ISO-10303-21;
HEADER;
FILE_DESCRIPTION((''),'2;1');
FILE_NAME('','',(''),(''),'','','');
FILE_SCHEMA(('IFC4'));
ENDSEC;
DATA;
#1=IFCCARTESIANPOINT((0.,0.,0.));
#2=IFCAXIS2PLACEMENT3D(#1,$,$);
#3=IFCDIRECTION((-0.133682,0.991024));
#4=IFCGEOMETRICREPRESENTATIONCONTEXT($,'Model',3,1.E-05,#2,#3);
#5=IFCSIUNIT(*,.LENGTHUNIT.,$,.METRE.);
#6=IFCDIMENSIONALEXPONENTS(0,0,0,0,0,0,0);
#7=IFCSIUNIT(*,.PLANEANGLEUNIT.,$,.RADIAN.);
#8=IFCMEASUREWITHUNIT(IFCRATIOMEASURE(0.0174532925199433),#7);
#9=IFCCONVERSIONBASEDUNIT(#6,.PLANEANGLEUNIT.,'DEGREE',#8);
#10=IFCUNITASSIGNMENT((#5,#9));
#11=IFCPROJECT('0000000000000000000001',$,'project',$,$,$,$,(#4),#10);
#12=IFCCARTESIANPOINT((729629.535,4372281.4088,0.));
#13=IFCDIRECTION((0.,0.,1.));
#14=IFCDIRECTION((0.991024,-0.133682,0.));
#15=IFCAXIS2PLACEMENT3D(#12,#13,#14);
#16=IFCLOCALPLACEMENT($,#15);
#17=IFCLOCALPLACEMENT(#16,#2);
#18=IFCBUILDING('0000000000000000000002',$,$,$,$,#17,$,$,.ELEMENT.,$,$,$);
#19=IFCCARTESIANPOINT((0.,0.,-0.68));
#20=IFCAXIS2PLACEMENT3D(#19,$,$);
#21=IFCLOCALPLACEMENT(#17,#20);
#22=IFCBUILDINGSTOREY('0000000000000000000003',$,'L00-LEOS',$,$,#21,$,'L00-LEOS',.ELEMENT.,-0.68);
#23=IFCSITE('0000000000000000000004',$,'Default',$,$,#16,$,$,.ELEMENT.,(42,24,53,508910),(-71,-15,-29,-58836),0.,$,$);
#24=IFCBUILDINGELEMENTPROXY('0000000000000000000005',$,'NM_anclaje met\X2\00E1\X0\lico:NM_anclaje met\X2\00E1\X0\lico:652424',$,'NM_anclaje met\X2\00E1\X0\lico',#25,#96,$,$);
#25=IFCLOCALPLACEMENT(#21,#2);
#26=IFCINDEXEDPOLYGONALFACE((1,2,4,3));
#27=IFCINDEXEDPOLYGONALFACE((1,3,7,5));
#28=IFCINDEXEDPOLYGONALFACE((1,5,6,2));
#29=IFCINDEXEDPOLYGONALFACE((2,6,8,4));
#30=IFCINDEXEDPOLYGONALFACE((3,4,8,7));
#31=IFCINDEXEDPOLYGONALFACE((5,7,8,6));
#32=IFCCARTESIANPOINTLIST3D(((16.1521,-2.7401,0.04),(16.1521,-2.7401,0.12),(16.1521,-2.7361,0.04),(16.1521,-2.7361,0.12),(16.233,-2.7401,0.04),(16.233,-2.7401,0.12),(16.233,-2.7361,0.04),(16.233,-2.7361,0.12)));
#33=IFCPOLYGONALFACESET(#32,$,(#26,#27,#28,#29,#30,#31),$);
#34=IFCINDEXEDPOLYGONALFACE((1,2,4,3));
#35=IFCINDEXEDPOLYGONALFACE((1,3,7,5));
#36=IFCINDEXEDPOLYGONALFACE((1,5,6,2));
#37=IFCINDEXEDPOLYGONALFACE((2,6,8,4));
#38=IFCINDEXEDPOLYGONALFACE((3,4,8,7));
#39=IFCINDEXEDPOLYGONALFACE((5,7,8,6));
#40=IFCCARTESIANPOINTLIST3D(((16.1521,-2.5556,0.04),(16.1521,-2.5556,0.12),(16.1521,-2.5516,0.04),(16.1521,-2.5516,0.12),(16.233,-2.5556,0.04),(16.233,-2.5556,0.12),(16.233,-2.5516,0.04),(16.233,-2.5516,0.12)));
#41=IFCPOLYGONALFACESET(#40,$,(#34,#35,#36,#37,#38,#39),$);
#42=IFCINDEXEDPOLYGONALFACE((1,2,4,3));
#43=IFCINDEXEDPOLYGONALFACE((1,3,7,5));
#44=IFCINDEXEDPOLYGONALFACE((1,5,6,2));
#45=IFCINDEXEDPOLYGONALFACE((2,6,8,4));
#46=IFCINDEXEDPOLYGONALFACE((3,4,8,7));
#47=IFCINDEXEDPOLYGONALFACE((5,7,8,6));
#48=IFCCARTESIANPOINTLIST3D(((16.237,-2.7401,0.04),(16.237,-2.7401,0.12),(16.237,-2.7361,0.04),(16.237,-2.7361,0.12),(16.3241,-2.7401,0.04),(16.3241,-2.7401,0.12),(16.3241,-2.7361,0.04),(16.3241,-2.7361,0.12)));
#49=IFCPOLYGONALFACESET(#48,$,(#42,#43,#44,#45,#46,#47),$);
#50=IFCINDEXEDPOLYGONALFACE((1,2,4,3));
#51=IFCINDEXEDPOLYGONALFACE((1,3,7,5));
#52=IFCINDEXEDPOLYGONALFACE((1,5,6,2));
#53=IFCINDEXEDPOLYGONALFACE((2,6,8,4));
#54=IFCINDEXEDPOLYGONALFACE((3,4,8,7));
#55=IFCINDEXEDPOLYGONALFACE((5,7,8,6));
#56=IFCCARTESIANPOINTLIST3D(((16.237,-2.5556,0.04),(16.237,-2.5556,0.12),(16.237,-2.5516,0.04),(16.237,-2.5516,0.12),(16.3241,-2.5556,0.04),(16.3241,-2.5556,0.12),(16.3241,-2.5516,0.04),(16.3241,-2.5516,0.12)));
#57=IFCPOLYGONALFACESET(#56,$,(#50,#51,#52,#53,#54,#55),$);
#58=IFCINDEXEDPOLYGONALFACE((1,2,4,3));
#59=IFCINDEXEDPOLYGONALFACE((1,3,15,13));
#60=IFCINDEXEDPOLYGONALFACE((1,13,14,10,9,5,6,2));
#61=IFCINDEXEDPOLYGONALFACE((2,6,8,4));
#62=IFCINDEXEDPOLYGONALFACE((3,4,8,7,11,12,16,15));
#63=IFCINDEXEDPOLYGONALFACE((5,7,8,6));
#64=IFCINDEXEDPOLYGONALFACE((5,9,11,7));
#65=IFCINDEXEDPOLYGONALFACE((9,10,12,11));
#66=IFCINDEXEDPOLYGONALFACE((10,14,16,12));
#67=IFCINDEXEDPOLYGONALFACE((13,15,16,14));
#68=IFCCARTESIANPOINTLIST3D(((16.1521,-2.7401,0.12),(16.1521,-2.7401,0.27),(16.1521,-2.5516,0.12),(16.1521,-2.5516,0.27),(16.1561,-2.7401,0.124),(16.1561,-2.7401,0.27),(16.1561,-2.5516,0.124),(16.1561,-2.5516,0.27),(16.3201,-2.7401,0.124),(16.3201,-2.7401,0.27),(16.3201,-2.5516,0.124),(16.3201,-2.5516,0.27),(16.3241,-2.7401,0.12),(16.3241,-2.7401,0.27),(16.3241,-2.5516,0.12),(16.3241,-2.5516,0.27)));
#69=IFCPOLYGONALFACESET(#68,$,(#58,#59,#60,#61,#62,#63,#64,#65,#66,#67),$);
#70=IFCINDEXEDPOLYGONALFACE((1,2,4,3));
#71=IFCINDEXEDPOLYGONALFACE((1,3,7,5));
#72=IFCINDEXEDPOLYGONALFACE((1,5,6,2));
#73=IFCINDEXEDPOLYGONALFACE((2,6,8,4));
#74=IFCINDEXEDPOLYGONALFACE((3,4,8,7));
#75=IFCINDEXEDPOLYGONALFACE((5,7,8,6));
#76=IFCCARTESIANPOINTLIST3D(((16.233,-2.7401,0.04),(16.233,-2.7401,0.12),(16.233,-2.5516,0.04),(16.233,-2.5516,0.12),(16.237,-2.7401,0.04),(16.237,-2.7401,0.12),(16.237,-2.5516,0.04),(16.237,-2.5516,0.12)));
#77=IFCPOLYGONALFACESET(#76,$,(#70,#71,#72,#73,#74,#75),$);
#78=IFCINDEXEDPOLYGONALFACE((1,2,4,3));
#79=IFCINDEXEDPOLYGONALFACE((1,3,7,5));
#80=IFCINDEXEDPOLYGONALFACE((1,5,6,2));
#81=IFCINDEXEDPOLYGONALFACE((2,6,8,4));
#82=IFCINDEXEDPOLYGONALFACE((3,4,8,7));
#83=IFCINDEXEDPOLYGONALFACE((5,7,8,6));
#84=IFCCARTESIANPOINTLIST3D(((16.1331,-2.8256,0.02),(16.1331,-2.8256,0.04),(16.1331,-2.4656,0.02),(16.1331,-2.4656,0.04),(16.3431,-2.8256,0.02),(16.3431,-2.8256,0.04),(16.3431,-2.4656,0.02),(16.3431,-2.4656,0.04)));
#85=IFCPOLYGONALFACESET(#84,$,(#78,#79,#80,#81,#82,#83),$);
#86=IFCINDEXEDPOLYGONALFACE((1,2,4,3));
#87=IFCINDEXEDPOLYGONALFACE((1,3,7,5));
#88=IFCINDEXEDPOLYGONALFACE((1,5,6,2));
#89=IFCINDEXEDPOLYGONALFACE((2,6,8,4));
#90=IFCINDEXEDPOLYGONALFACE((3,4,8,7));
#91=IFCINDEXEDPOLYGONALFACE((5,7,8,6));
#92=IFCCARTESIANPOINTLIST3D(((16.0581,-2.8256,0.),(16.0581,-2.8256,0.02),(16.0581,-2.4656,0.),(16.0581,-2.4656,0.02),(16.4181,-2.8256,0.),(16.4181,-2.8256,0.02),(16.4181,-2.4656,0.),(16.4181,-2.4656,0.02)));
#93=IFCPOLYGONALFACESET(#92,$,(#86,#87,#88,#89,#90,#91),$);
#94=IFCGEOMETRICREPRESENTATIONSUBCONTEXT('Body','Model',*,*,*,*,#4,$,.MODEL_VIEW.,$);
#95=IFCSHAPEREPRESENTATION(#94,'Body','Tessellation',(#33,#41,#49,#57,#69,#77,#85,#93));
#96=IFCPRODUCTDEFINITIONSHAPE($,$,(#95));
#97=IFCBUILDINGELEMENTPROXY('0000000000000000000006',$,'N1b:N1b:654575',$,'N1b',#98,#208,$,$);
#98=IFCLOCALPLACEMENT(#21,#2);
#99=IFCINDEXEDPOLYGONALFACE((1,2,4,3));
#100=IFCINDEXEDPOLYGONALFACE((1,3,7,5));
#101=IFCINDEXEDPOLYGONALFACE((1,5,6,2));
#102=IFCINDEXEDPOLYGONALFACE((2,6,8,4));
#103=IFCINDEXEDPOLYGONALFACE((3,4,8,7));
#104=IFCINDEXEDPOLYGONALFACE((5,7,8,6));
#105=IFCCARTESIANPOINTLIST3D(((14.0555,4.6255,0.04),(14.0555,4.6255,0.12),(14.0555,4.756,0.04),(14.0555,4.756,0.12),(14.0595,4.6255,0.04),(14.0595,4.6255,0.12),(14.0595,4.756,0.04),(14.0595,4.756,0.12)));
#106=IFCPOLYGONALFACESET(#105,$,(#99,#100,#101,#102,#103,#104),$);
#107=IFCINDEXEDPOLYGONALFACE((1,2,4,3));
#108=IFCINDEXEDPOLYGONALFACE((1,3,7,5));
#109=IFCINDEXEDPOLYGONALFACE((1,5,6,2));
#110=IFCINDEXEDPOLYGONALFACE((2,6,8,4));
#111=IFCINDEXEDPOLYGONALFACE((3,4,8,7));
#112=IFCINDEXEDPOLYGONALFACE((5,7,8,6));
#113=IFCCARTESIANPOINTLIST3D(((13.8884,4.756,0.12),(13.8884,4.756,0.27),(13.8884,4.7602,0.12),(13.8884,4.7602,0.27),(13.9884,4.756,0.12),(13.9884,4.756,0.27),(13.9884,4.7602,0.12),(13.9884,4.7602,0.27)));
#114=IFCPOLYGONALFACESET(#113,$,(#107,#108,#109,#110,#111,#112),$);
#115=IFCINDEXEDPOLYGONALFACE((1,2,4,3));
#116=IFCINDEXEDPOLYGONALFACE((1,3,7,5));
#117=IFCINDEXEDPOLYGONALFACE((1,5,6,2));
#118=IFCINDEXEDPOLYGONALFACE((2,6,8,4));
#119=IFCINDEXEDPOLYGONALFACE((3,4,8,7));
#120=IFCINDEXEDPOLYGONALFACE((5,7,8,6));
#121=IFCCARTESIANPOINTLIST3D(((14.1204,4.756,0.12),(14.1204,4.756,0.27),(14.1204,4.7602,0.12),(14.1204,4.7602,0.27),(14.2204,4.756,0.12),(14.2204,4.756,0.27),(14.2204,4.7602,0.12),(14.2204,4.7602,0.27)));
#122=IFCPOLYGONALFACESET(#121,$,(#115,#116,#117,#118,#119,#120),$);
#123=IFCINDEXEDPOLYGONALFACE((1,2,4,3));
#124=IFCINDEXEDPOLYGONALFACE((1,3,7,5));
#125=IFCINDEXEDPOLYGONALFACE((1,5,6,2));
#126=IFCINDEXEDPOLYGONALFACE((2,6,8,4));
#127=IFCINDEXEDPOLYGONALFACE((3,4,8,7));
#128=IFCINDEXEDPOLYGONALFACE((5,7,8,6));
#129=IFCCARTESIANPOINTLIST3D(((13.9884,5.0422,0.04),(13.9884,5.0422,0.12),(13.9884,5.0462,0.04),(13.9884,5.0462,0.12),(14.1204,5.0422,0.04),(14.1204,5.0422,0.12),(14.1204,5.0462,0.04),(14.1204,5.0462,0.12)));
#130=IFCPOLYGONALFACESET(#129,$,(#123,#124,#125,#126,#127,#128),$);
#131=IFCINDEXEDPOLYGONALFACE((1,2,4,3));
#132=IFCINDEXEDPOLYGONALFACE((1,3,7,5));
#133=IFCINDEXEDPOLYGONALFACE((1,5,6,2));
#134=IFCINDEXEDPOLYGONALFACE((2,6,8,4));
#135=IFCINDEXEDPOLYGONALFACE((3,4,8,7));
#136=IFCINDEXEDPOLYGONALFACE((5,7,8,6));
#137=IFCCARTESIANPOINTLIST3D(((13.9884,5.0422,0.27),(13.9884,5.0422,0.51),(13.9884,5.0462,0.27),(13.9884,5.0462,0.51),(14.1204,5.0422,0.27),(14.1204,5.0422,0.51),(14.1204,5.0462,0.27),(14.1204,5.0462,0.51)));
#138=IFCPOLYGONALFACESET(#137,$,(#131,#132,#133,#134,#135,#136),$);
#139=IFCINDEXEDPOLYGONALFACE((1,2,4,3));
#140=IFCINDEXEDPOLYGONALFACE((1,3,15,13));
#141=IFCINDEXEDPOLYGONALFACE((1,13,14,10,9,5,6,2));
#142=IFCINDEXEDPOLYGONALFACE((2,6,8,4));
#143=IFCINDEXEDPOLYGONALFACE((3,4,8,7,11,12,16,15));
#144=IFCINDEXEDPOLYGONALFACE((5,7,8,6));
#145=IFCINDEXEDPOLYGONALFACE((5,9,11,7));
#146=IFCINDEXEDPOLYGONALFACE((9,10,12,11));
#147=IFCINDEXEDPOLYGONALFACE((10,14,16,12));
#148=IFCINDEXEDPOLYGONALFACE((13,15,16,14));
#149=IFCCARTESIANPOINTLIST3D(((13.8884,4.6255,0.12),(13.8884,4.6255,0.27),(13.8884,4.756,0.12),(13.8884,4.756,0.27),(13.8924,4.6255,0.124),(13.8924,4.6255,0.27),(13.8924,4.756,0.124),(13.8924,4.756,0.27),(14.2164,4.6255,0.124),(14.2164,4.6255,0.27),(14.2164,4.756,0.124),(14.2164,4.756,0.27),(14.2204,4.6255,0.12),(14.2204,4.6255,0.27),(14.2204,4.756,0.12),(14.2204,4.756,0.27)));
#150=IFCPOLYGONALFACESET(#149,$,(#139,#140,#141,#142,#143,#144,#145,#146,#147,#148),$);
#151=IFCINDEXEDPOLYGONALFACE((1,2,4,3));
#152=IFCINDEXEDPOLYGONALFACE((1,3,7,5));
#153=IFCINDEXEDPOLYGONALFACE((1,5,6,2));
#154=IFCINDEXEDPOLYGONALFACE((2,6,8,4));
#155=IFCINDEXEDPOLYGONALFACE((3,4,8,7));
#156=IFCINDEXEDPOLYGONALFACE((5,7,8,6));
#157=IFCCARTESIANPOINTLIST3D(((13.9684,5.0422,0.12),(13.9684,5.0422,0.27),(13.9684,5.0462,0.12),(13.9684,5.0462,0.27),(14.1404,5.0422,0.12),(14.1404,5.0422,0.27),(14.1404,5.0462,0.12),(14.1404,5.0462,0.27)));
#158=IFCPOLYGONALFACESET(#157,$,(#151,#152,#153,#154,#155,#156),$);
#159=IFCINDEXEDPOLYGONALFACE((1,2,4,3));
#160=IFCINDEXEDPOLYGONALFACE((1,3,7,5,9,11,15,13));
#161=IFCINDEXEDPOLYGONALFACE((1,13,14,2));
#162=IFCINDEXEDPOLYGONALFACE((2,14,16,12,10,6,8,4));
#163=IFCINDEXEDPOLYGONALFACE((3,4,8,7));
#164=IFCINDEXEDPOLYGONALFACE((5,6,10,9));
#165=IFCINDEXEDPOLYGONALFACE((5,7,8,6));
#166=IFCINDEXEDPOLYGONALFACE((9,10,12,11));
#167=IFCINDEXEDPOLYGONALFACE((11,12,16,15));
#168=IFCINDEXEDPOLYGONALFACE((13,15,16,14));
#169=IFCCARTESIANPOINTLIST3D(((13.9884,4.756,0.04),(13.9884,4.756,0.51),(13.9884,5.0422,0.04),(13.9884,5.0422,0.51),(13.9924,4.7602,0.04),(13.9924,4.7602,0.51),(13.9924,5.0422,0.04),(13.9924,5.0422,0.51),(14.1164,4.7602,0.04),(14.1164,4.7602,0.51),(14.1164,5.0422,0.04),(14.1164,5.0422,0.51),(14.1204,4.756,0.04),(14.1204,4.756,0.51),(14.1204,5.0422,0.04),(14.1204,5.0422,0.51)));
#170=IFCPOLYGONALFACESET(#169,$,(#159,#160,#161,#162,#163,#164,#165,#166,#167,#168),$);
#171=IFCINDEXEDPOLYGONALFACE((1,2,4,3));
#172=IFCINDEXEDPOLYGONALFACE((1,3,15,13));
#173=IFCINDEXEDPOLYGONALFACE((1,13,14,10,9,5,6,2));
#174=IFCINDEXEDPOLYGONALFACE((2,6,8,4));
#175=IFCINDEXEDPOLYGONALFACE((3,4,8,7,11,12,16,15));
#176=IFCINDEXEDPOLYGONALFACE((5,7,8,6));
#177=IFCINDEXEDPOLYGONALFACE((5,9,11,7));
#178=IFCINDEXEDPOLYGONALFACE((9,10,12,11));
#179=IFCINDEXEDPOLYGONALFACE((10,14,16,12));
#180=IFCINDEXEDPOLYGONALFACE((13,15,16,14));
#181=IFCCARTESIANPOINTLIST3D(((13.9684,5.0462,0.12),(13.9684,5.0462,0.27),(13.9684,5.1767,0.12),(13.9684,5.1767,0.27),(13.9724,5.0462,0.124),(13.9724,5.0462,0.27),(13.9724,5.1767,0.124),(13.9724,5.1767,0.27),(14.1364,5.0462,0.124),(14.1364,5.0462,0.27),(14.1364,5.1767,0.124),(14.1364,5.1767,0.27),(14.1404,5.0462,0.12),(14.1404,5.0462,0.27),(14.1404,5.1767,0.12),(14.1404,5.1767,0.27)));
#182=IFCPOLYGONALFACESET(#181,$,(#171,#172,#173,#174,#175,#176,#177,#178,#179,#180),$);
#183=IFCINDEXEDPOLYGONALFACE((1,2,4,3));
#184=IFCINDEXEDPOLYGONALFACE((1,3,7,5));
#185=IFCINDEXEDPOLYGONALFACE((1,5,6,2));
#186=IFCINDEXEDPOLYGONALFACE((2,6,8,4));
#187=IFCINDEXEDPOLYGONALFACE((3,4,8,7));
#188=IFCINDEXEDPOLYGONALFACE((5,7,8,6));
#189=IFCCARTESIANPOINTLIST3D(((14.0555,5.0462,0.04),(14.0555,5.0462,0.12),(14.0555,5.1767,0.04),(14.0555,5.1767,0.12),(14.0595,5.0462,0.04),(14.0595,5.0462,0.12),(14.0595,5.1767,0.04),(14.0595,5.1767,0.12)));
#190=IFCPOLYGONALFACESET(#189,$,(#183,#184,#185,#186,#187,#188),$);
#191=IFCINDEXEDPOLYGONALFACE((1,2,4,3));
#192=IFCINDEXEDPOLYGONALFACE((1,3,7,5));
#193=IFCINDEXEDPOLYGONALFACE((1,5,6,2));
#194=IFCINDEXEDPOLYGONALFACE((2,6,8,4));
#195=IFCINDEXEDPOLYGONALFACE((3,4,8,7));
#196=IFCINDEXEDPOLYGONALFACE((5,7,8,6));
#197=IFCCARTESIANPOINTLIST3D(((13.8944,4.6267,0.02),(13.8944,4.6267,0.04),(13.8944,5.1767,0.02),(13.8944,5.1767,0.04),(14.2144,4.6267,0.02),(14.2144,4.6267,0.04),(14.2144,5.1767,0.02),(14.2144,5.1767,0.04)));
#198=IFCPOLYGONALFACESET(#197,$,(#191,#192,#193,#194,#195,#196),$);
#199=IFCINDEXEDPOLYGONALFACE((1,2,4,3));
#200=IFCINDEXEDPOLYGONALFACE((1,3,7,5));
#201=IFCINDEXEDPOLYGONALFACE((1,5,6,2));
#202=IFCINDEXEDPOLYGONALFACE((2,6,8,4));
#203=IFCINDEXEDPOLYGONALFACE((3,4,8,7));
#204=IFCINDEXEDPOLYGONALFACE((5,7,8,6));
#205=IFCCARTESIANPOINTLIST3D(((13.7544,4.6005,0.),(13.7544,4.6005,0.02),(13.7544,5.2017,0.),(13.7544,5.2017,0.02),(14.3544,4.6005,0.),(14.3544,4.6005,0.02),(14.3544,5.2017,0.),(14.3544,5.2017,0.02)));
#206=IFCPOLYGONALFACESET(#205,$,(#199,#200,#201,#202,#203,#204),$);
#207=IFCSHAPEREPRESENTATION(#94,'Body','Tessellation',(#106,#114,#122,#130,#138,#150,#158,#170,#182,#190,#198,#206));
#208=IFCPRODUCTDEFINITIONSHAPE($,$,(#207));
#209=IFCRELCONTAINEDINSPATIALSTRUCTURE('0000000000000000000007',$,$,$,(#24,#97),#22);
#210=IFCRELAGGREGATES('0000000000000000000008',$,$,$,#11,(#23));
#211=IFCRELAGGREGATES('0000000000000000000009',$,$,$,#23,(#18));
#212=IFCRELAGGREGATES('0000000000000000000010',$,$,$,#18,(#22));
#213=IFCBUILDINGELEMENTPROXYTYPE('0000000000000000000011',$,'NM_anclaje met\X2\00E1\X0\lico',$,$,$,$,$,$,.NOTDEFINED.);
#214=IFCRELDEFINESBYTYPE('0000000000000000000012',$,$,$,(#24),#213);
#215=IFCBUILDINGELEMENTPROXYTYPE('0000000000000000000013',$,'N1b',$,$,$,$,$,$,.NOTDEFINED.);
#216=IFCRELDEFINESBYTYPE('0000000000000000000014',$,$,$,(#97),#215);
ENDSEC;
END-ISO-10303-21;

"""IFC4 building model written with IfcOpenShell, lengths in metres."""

from ifc_helpers import new_model, entity, si_unit, converted_unit, direction, frame, frame_2d, origin, origin_2d_with_axis, place, context, subcontext, project, spatial, polyline, rectangle, outline, extrude, source, transform, mapped, type_object, type_shapes, element, save


model = new_model("IFC4")

# Units and contexts
model_context = context("Model", 3, precision=1e-05, world=origin(), true_north=direction((-0.133682, 0.991024)))
body_context = subcontext(model_context, "Body", "Model", "MODEL_VIEW")
ifc_project = project(units=[si_unit("LENGTHUNIT", "METRE"), converted_unit("PLANEANGLEUNIT", "DEGREE", entity("IfcRatioMeasure", 0.0174532925199433), si_unit("PLANEANGLEUNIT", "RADIAN"), dimensions=[0, 0, 0, 0, 0, 0, 0])], contexts=[model_context])

# Site, building, storey
site_placement = place(None, frame((729629.535, 4372281.4088, 0.0), z_axis=(0.0, 0.0, 1.0), x_axis=(0.991024, -0.133682, 0.0)))
site = spatial("IfcSite", under=ifc_project, at=site_placement, Name="Default", CompositionType="ELEMENT", RefLatitude=(42, 24, 53, 508910), RefLongitude=(-71, -15, -29, -58836), RefElevation=0.0)
building_placement = place(site_placement, origin())
building = spatial("IfcBuilding", under=site, at=building_placement, CompositionType="ELEMENT")
storey_placement = place(building_placement, frame((0.0, 0.0, -0.68)))
storey = spatial("IfcBuildingStorey", under=building, at=storey_placement, Name="L00-LEOS", LongName="L00-LEOS", CompositionType="ELEMENT", Elevation=-0.68)

# Building element proxies
building_element_proxy_type_1 = type_object("IfcBuildingElementProxyType", Name="NM_anclaje metálico")
shared_shape_1 = source(origin(), body_context, "Body", "SweptSolid", [
    extrude(rectangle(XDim=0.0809, YDim=0.004, at=frame_2d((0.0, 0.0), x_axis=(1.0, 0.0))), frame((0.0925, -0.0424, 0.04), z_axis=(0.0, 0.0, 1.0), x_axis=(0.0, 1.0, 0.0)), (0.0, 0.0, 1.0), 0.08),
    extrude(rectangle(XDim=0.0809, YDim=0.004, at=frame_2d((0.0, 0.0), x_axis=(1.0, 0.0))), frame((-0.092, -0.0424, 0.04), z_axis=(0.0, 0.0, 1.0), x_axis=(0.0, 1.0, 0.0)), (0.0, 0.0, 1.0), 0.08),
    extrude(rectangle(XDim=0.0871, YDim=0.004, at=origin_2d_with_axis()), frame((0.0925, 0.0456, 0.04), z_axis=(0.0, 0.0, 1.0), x_axis=(0.0, 1.0, 0.0)), (0.0, 0.0, 1.0), 0.08),
    extrude(rectangle(XDim=0.0871, YDim=0.004, at=frame_2d((0.0, 0.0), x_axis=(1.0, 0.0))), frame((-0.092, 0.0456, 0.04), z_axis=(0.0, 0.0, 1.0), x_axis=(0.0, 1.0, 0.0)), (0.0, 0.0, 1.0), 0.08),
    extrude(outline(polyline([(-0.076, -0.086), (0.074, -0.086), (0.074, -0.082), (-0.072, -0.082), (-0.072, 0.082), (0.074, 0.082), (0.074, 0.086), (-0.076, 0.086), (-0.076, -0.086)])), frame((-0.094, 0.0031, 0.196), z_axis=(1.0, 0.0, 0.0), x_axis=(0.0, 0.0, 1.0)), (0.0, 0.0, 1.0), 0.1885),
    extrude(rectangle(XDim=0.004, YDim=0.1885, at=frame_2d((0.0, 0.0), x_axis=(1.0, 0.0))), frame((0.0002, 0.0, 0.04), z_axis=(0.0, 0.0, 1.0), x_axis=(0.0, -1.0, 0.0)), (0.0, 0.0, 1.0), 0.08),
    extrude(rectangle(XDim=0.36, YDim=0.21, at=frame_2d((0.0, 0.0), x_axis=(1.0, 0.0))), frame((0.0, 0.0031, 0.02), z_axis=(0.0, 0.0, 1.0), x_axis=(-1.0, 0.0, 0.0)), (0.0, 0.0, 1.0), 0.02),
    extrude(rectangle(XDim=0.36, YDim=0.36, at=frame_2d((0.0, 0.0), x_axis=(1.0, 0.0))), frame((0.0, 0.0031, 0.0), z_axis=(0.0, 0.0, 1.0), x_axis=(-1.0, 0.0, 0.0)), (0.0, 0.0, 1.0), 0.02),
])
type_shapes(building_element_proxy_type_1, [shared_shape_1])
for number, where, z_axis, x_axis, name in (
    (1, (16.235, -2.6456, 0.0), (0.0, 0.0, 1.0), (0.0, -1.0, 0.0), "NM_anclaje metálico:NM_anclaje metálico:652424"),
):
    element("IfcBuildingElementProxy", number, at=place(storey_placement, frame(where, z_axis=z_axis, x_axis=x_axis)), inside=storey, type_object=building_element_proxy_type_1, Name=name, ObjectType="NM_anclaje metálico", context=body_context, shape_type="MappedRepresentation", body=[
        mapped(shared_shape_1, transform((0.0, 0.0, 0.0), scale=1.0)),
    ])
building_element_proxy_type_2 = type_object("IfcBuildingElementProxyType", Name="N1b")
shared_shape_2 = source(origin(), body_context, "Body", "SweptSolid", [
    extrude(rectangle(XDim=0.1305, YDim=0.004, at=origin_2d_with_axis()), frame((0.2103, 0.0, 0.04)), (0.0, 0.0, 1.0), 0.08),
    extrude(rectangle(XDim=0.0042, YDim=0.1, at=frame_2d((0.0, 0.0), x_axis=(1.0, 0.0))), frame((0.143, -0.1191, 0.12), z_axis=(0.0, 0.0, 1.0), x_axis=(-1.0, 0.0, 0.0)), (0.0, 0.0, 1.0), 0.15),
    extrude(rectangle(XDim=0.0042, YDim=0.1, at=frame_2d((0.0, 0.0), x_axis=(1.0, 0.0))), frame((0.143, 0.1129, 0.12), z_axis=(0.0, 0.0, 1.0), x_axis=(-1.0, 0.0, 0.0)), (0.0, 0.0, 1.0), 0.15),
    extrude(rectangle(XDim=0.004, YDim=0.132, at=frame_2d((0.0, 0.0), x_axis=(1.0, 0.0))), frame((-0.1431, -0.0031, 0.04), z_axis=(0.0, 0.0, 1.0), x_axis=(-1.0, 0.0, 0.0)), (0.0, 0.0, 1.0), 0.08),
    extrude(rectangle(XDim=0.004, YDim=0.132, at=frame_2d((0.0, 0.0), x_axis=(1.0, 0.0))), frame((-0.1431, -0.0031, 0.27), z_axis=(0.0, 0.0, 1.0), x_axis=(-1.0, 0.0, 0.0)), (0.0, 0.0, 1.0), 0.24),
    extrude(outline(polyline([(-0.166, -0.076), (0.166, -0.076), (0.166, 0.074), (0.162, 0.074), (0.162, -0.072), (-0.162, -0.072), (-0.162, 0.074), (-0.166, 0.074), (-0.166, -0.076)])), frame((0.1451, -0.0031, 0.196), z_axis=(1.0, 0.0, 0.0), x_axis=(0.0, 1.0, 0.0)), (0.0, 0.0, 1.0), 0.1305),
    extrude(rectangle(XDim=0.004, YDim=0.172, at=frame_2d((0.0, 0.0), x_axis=(1.0, 0.0))), frame((-0.1431, -0.0031, 0.12), z_axis=(0.0, 0.0, 1.0), x_axis=(-1.0, 0.0, 0.0)), (0.0, 0.0, 1.0), 0.15),
    extrude(outline(polyline([(-0.066, -0.1441), (0.066, -0.1441), (0.066, 0.142), (0.062, 0.142), (0.062, -0.14), (-0.062, -0.14), (-0.062, 0.142), (-0.066, 0.142), (-0.066, -0.1441)])), frame((0.001, -0.0031, 0.04), z_axis=(0.0, 0.0, 1.0), x_axis=(0.0, 1.0, 0.0)), (0.0, 0.0, 1.0), 0.47),
    extrude(outline(polyline([(-0.086, -0.076), (0.086, -0.076), (0.086, 0.074), (0.082, 0.074), (0.082, -0.072), (-0.082, -0.072), (-0.082, 0.074), (-0.086, 0.074), (-0.086, -0.076)])), frame((-0.2756, -0.0031, 0.196), z_axis=(1.0, 0.0, 0.0), x_axis=(0.0, 1.0, 0.0)), (0.0, 0.0, 1.0), 0.1305),
    extrude(rectangle(XDim=0.1305, YDim=0.004, at=origin_2d_with_axis()), frame((-0.2103, 0.0, 0.04)), (0.0, 0.0, 1.0), 0.08),
    extrude(rectangle(XDim=0.32, YDim=0.55, at=frame_2d((0.0, 0.0), x_axis=(1.0, 0.0))), frame((-0.0006, -0.0031, 0.02), z_axis=(0.0, 0.0, 1.0), x_axis=(0.0, 1.0, 0.0)), (0.0, 0.0, 1.0), 0.02),
    extrude(rectangle(XDim=0.6, YDim=0.6012, at=frame_2d((0.0, 0.0), x_axis=(1.0, 0.0))), frame((0.0, -0.0031, 0.0), z_axis=(0.0, 0.0, 1.0), x_axis=(0.0, 1.0, 0.0)), (0.0, 0.0, 1.0), 0.02),
])
type_shapes(building_element_proxy_type_2, [shared_shape_2])
proxy_1_placement = place(storey_placement, frame((14.0575, 4.9011, 0.0), z_axis=(0.0, 0.0, 1.0), x_axis=(0.0, -1.0, 0.0)))
element("IfcBuildingElementProxy", 2, at=proxy_1_placement, inside=storey, type_object=building_element_proxy_type_2, Name="N1b:N1b:654575", ObjectType="N1b", context=body_context, shape_type="MappedRepresentation", body=[
    mapped(shared_shape_2, transform((0.0, 0.0, 0.0), scale=1.0)),
])

save(model, "model.ifc")
